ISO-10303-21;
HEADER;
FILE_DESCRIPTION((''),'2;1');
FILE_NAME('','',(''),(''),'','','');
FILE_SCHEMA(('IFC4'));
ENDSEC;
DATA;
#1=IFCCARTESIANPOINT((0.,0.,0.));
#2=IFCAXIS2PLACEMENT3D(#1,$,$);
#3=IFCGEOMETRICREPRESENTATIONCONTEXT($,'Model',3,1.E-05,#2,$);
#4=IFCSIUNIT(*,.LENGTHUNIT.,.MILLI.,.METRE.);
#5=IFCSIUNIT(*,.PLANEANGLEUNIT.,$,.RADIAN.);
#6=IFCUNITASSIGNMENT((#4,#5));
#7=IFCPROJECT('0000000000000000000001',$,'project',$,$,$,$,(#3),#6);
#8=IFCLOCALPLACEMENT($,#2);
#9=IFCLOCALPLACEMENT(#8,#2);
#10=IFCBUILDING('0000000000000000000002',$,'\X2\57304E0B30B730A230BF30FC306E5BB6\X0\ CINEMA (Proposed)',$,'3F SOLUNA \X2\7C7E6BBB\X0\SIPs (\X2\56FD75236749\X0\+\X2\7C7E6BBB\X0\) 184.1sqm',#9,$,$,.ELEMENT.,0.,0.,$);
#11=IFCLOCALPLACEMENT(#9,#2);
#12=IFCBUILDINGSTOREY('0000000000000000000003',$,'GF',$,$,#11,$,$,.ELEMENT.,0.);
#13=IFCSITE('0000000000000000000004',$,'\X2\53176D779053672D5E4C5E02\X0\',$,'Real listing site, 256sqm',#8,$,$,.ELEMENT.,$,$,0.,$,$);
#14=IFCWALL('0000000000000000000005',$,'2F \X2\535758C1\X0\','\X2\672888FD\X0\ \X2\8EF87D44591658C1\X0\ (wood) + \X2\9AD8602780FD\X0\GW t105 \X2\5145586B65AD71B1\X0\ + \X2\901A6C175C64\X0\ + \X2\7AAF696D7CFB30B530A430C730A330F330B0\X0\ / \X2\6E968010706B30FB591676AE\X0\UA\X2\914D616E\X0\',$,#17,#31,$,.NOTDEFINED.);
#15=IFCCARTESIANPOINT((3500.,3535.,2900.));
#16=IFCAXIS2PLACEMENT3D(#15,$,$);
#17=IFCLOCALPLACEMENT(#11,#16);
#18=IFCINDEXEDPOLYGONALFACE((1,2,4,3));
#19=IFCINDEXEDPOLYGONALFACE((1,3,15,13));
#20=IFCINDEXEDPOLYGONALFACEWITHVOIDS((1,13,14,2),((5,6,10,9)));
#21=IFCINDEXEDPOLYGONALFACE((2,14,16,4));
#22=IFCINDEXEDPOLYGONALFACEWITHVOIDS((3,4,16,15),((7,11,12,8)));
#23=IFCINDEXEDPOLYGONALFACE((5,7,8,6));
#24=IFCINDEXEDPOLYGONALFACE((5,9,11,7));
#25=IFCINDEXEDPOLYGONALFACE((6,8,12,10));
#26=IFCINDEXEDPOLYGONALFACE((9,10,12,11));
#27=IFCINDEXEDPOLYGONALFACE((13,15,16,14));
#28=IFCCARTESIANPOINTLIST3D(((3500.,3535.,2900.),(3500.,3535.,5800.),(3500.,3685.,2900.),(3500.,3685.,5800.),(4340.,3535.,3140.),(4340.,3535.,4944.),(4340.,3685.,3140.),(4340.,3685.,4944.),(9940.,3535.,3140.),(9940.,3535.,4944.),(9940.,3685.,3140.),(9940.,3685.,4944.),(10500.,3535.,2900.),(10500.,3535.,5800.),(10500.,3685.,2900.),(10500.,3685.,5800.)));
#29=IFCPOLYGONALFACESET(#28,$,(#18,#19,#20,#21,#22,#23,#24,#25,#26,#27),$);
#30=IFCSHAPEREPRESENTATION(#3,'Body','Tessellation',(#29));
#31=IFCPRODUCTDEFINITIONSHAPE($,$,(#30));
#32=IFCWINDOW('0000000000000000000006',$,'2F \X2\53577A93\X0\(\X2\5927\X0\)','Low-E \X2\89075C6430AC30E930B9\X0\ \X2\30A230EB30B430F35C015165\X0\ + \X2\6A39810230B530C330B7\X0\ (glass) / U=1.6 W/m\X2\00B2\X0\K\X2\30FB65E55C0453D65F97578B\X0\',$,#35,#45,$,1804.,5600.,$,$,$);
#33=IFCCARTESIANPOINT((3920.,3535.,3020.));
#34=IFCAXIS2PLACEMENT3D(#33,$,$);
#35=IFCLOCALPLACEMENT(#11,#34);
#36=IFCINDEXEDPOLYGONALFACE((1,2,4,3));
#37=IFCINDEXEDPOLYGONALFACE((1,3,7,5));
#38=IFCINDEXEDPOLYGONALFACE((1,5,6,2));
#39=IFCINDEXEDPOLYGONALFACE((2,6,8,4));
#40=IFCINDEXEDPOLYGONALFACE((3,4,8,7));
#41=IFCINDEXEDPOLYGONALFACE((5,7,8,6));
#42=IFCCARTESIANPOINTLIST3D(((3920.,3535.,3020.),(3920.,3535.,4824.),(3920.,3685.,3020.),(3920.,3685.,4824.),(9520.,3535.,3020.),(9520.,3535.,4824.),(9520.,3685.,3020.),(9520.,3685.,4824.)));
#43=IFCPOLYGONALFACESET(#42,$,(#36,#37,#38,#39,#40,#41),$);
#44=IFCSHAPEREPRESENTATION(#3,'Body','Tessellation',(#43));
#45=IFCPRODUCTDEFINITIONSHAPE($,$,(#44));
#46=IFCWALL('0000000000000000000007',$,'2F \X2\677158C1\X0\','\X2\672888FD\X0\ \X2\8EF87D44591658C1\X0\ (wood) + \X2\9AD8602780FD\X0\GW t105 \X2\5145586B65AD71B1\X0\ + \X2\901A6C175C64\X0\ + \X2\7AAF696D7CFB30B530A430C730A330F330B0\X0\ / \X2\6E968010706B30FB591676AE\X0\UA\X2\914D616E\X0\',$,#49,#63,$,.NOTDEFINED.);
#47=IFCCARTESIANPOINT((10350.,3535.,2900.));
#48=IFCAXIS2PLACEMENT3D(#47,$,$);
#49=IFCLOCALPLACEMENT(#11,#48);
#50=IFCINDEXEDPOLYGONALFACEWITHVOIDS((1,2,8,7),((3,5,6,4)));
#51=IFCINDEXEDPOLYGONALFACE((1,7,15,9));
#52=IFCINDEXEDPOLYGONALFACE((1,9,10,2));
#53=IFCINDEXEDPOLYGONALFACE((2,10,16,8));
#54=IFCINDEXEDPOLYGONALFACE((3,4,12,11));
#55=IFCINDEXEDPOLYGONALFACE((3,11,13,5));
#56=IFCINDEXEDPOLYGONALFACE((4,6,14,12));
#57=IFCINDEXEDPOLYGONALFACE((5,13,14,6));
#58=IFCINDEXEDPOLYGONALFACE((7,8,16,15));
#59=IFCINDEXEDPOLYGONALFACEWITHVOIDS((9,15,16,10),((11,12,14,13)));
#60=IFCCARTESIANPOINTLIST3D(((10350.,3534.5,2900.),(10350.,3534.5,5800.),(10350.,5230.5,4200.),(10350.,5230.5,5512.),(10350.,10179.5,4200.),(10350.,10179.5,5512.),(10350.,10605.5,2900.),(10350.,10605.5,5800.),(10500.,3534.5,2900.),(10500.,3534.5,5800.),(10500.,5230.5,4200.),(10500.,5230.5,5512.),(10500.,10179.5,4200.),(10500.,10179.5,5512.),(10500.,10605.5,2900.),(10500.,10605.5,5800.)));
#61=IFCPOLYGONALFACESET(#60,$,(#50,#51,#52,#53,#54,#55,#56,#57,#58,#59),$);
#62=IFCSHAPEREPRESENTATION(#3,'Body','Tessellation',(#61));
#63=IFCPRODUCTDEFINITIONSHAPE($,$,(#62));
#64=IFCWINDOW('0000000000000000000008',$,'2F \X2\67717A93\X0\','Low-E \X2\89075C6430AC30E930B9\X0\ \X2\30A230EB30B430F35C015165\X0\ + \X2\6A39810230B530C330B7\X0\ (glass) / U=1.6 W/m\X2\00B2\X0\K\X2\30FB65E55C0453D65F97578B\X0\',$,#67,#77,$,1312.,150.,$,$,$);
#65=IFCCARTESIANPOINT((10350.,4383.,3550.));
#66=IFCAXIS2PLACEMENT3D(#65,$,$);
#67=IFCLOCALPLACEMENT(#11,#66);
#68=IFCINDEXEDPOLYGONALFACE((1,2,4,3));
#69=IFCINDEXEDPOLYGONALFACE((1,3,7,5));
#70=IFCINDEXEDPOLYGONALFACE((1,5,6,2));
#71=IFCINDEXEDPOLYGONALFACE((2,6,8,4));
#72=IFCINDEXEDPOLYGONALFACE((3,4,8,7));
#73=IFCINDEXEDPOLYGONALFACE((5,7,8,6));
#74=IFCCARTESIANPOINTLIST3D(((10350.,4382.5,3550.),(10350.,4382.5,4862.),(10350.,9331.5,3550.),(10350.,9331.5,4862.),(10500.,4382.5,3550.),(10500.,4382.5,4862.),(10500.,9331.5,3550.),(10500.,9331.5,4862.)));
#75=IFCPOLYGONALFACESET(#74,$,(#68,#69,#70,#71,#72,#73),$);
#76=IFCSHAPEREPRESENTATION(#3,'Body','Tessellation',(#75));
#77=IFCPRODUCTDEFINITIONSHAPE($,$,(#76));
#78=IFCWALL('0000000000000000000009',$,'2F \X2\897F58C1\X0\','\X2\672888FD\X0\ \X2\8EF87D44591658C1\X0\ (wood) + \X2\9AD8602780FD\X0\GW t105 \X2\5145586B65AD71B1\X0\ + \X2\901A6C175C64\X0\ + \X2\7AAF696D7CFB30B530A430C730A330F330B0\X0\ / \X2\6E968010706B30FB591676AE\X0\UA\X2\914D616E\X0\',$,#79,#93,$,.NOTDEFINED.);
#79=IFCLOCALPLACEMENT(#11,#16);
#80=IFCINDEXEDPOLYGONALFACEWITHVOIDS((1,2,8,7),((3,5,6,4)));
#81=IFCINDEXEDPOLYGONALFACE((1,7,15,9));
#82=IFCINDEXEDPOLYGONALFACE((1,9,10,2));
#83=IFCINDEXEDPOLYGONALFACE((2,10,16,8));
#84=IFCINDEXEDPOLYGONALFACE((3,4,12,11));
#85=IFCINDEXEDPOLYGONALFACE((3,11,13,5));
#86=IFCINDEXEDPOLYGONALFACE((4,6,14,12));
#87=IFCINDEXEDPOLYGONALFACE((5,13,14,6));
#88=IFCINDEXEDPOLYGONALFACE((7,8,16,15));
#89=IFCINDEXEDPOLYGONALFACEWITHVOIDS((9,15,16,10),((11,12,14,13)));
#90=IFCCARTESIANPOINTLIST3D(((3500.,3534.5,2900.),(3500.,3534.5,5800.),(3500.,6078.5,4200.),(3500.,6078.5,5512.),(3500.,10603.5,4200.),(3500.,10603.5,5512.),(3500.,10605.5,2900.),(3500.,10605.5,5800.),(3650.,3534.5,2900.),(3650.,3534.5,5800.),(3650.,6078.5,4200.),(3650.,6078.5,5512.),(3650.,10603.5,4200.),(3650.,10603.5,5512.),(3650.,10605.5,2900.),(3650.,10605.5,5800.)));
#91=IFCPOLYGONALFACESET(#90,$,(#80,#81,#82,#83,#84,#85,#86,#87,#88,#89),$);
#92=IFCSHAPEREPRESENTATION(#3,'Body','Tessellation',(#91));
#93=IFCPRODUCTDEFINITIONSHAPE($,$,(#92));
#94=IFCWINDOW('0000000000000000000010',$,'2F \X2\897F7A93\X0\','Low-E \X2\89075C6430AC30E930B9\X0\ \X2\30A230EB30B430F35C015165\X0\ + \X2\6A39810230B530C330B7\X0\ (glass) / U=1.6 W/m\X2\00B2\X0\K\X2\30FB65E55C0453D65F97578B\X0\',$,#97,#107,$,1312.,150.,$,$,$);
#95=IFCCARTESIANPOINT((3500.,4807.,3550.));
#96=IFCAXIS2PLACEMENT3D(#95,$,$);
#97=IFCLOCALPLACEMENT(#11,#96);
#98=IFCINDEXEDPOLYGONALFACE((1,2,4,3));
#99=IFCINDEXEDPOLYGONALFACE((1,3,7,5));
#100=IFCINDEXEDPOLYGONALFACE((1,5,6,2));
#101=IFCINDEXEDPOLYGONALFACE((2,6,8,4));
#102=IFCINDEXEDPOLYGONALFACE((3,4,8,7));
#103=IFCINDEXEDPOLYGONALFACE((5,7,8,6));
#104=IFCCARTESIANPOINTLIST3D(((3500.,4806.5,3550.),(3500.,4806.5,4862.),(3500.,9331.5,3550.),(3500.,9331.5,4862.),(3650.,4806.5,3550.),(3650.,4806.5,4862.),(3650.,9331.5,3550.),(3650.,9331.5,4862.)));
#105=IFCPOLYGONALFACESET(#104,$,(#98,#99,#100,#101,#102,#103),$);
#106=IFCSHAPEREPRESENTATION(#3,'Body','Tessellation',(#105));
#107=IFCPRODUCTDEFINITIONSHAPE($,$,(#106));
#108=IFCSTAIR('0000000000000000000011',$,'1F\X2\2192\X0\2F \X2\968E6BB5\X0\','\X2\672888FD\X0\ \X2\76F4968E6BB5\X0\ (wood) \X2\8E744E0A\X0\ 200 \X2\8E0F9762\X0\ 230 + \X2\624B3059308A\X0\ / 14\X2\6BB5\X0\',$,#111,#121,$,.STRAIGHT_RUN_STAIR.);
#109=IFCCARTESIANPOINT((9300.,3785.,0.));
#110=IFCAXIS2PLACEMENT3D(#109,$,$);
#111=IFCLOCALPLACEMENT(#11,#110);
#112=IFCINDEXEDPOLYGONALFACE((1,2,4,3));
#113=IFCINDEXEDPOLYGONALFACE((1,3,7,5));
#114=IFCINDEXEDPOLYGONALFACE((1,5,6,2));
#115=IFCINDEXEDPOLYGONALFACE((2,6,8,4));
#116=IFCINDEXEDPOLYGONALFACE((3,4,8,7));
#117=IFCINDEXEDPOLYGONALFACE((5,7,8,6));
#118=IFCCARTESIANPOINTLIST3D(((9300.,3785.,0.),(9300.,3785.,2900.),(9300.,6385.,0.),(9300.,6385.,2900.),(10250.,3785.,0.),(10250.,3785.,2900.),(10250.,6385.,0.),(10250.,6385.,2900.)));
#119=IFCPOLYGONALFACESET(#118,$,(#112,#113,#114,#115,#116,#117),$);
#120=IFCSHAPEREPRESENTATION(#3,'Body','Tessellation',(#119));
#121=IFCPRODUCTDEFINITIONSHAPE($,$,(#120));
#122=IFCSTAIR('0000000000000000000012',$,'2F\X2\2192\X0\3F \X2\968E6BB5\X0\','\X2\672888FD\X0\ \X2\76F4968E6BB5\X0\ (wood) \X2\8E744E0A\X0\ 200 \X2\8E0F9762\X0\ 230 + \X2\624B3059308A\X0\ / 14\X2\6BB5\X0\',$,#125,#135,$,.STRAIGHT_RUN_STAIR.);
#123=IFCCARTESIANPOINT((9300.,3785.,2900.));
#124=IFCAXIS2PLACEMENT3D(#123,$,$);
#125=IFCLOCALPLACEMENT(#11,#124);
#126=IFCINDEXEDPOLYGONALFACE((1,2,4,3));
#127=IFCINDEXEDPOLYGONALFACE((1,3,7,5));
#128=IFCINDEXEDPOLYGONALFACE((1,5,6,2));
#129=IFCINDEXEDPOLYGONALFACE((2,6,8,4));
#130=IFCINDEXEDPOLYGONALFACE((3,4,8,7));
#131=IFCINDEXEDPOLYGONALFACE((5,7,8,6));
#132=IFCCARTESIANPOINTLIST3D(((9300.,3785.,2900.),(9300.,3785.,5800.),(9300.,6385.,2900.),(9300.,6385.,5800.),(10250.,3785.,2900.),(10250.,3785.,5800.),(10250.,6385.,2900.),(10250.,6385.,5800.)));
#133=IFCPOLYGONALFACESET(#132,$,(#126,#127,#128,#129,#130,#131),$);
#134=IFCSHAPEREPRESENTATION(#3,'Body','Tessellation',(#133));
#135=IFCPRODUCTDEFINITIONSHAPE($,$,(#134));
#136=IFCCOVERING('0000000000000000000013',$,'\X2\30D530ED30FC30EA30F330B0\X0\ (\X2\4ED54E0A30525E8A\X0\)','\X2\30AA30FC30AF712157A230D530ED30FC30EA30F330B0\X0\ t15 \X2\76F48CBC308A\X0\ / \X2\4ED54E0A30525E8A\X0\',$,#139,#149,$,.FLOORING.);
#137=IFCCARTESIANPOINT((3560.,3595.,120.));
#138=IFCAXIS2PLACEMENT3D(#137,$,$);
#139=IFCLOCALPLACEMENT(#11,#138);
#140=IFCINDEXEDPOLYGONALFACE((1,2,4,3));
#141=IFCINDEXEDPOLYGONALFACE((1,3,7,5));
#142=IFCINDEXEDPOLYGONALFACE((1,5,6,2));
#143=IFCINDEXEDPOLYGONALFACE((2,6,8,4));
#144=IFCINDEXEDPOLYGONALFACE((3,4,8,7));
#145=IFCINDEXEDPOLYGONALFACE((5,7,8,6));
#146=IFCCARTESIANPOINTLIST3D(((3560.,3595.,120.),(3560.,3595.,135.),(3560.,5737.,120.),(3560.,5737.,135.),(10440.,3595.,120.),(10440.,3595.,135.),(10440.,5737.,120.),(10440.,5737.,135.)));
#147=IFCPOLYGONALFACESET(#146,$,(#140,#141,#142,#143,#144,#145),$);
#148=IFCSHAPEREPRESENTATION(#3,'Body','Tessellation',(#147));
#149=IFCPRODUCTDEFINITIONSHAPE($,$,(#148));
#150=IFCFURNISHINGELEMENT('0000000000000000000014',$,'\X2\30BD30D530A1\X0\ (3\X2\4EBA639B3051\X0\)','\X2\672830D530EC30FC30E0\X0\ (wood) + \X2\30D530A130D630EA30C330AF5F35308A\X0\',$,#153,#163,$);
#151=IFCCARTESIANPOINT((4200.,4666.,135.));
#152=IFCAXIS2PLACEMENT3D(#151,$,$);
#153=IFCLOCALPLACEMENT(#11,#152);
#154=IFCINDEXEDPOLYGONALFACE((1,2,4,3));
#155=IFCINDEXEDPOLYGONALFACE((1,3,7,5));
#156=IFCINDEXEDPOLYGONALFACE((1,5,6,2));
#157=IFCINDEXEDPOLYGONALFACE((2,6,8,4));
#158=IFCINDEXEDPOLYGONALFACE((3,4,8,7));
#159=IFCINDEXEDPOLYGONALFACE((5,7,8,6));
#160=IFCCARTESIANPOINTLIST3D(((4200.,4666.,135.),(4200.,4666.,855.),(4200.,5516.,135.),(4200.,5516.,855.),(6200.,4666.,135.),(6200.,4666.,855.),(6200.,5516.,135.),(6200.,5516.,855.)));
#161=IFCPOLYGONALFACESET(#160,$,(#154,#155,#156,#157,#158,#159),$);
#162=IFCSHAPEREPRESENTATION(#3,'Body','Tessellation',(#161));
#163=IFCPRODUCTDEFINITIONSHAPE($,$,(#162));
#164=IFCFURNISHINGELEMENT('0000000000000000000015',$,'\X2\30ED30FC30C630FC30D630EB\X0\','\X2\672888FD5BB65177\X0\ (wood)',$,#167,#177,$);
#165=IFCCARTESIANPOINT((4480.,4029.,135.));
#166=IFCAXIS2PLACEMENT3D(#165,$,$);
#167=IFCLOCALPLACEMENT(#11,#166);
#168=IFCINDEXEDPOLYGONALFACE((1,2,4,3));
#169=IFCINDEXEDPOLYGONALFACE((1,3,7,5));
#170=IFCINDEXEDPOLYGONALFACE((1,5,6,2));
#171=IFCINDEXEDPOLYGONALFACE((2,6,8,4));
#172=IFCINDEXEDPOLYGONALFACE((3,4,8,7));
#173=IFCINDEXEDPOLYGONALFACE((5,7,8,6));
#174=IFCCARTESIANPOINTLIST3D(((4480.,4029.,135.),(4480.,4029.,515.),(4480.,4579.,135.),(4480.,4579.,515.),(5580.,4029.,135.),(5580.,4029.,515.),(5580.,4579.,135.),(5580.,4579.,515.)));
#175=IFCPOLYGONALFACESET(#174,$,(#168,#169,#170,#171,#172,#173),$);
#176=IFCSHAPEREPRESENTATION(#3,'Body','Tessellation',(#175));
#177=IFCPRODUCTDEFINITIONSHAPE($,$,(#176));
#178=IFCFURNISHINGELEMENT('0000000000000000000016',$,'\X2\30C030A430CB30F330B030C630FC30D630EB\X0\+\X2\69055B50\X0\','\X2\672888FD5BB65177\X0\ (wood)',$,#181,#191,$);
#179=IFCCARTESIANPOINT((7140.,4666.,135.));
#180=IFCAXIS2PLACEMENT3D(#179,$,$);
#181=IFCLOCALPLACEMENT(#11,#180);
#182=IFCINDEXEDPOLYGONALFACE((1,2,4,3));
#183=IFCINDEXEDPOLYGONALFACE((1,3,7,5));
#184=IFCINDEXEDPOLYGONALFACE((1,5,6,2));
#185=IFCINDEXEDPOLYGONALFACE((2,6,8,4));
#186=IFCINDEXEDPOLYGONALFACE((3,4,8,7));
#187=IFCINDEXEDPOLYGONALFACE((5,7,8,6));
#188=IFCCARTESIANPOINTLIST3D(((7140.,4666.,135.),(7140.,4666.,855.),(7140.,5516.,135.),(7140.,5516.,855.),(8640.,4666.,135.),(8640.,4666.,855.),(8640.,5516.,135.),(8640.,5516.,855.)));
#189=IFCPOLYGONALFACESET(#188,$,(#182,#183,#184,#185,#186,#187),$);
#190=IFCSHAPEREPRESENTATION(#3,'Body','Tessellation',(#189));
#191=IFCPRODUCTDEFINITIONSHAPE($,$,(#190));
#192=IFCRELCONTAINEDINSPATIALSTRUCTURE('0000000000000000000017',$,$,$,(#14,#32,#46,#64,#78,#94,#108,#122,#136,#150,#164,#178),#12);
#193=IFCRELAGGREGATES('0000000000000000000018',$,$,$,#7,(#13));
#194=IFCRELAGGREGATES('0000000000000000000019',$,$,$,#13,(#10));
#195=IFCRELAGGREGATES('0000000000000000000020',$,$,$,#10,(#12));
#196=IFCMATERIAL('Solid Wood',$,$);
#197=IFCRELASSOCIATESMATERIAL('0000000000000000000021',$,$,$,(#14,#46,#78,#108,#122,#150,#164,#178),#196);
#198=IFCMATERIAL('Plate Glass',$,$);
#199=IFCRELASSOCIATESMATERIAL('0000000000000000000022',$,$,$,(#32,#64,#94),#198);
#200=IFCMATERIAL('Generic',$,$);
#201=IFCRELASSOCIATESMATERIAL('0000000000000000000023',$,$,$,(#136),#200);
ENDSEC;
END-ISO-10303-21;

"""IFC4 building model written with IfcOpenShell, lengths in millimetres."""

from ifc_helpers import new_model, si_unit, frame, frame_2d, origin, place, context, project, spatial, rectangle, extrude, material, element, fill, save


model = new_model("IFC4")

# Units and contexts
model_context = context("Model", 3, precision=1e-05, world=origin())
ifc_project = project(units=[si_unit("LENGTHUNIT", "METRE", prefix="MILLI"), si_unit("PLANEANGLEUNIT", "RADIAN")], contexts=[model_context])

# Site, building, storey
site_placement = place(None, origin())
site = spatial("IfcSite", under=ifc_project, at=site_placement, Name="北海道札幌市", ObjectType="Real listing site, 256sqm", CompositionType="ELEMENT", RefElevation=0.0)
building_placement = place(site_placement, origin())
building = spatial("IfcBuilding", under=site, at=building_placement, Name="地下シアターの家 CINEMA (Proposed)", ObjectType="3F SOLUNA 籾殻SIPs (国産杉+籾殻) 184.1sqm", CompositionType="ELEMENT", ElevationOfRefHeight=0.0, ElevationOfTerrain=0.0)
storey_placement = place(building_placement, origin())
storey = spatial("IfcBuildingStorey", under=building, at=storey_placement, Name="GF", CompositionType="ELEMENT", Elevation=0.0)

# Shared definitions
ifc_material_1 = material(Name="Solid Wood")

# Shared definitions
ifc_material_2 = material(Name="Plate Glass")

# Walls, openings, windows
wall_1_placement = place(storey_placement, frame((3500.0, 3535.0, 2900.0)))
wall_1 = element("IfcWall", 1, at=wall_1_placement, inside=storey, material=ifc_material_1, Name="2F 南壁", Description="木製 軸組外壁 (wood) + 高性能GW t105 充填断熱 + 通気層 + 窯業系サイディング / 準耐火・外皮UA配慮", PredefinedType="NOTDEFINED", context=model_context, shape_type="SweptSolid", body=[
    extrude(rectangle(XDim=7000.0, YDim=150.0, at=frame_2d((3500.0, 75.0))), frame((3500.0, 3535.0, 2900.0)), (0.0, 0.0, 1.0), 2900.0),
])
opening_1_placement = place(storey_placement, frame((3920.0, 3535.0, 3020.0)))
opening_1 = element("IfcOpeningElement", 2, at=opening_1_placement, cuts=wall_1, PredefinedType="NOTDEFINED", context=model_context, shape_type="SweptSolid", body=[
    extrude(rectangle(XDim=5600.0, YDim=150.0, at=frame_2d((2800.0, 75.0))), frame((3920.0, 3535.0, 3020.0)), (0.0, 0.0, 1.0), 1804.0),
])
window_1_placement = place(storey_placement, frame((3920.0, 3535.0, 3020.0)))
window_1 = element("IfcWindow", 3, at=window_1_placement, inside=storey, material=ifc_material_2, Name="2F 南窓(大)", Description="Low-E 複層ガラス アルゴン封入 + 樹脂サッシ (glass) / U=1.6 W/m²K・日射取得型", OverallHeight=1804.0, OverallWidth=5600.0, context=model_context, shape_type="SweptSolid", body=[
    extrude(rectangle(XDim=5600.0, YDim=150.0, at=frame_2d((2800.0, 75.0))), frame((3920.0, 3535.0, 3020.0)), (0.0, 0.0, 1.0), 1804.0),
])
fill(opening_1, window_1)
wall_2_placement = place(storey_placement, frame((10350.0, 3535.0, 2900.0)))
wall_2 = element("IfcWall", 4, at=wall_2_placement, inside=storey, material=ifc_material_1, Name="2F 東壁", Description="木製 軸組外壁 (wood) + 高性能GW t105 充填断熱 + 通気層 + 窯業系サイディング / 準耐火・外皮UA配慮", PredefinedType="NOTDEFINED", context=model_context, shape_type="SweptSolid", body=[
    extrude(rectangle(XDim=150.0, YDim=7071.0, at=frame_2d((75.0, 3535.0))), frame((10350.0, 3535.0, 2900.0)), (0.0, 0.0, 1.0), 2900.0),
])
opening_2_placement = place(storey_placement, frame((10350.0, 4383.0, 3550.0)))
opening_2 = element("IfcOpeningElement", 5, at=opening_2_placement, cuts=wall_2, PredefinedType="NOTDEFINED", context=model_context, shape_type="SweptSolid", body=[
    extrude(rectangle(XDim=150.0, YDim=4949.0, at=frame_2d((75.0, 2474.0))), frame((10350.0, 4383.0, 3550.0)), (0.0, 0.0, 1.0), 1312.0),
])
window_2_placement = place(storey_placement, frame((10350.0, 4383.0, 3550.0)))
window_2 = element("IfcWindow", 6, at=window_2_placement, inside=storey, material=ifc_material_2, Name="2F 東窓", Description="Low-E 複層ガラス アルゴン封入 + 樹脂サッシ (glass) / U=1.6 W/m²K・日射取得型", OverallHeight=1312.0, OverallWidth=150.0, context=model_context, shape_type="SweptSolid", body=[
    extrude(rectangle(XDim=150.0, YDim=4949.0, at=frame_2d((75.0, 2474.0))), frame((10350.0, 4383.0, 3550.0)), (0.0, 0.0, 1.0), 1312.0),
])
fill(opening_2, window_2)
wall_3_placement = place(storey_placement, frame((3500.0, 3535.0, 2900.0)))
wall_3 = element("IfcWall", 7, at=wall_3_placement, inside=storey, material=ifc_material_1, Name="2F 西壁", Description="木製 軸組外壁 (wood) + 高性能GW t105 充填断熱 + 通気層 + 窯業系サイディング / 準耐火・外皮UA配慮", PredefinedType="NOTDEFINED", context=model_context, shape_type="SweptSolid", body=[
    extrude(rectangle(XDim=150.0, YDim=7071.0, at=frame_2d((75.0, 3535.0))), frame((3500.0, 3535.0, 2900.0)), (0.0, 0.0, 1.0), 2900.0),
])
opening_3_placement = place(storey_placement, frame((3500.0, 4807.0, 3550.0)))
opening_3 = element("IfcOpeningElement", 8, at=opening_3_placement, cuts=wall_3, PredefinedType="NOTDEFINED", context=model_context, shape_type="SweptSolid", body=[
    extrude(rectangle(XDim=150.0, YDim=4525.0, at=frame_2d((75.0, 2262.0))), frame((3500.0, 4807.0, 3550.0)), (0.0, 0.0, 1.0), 1312.0),
])
window_3_placement = place(storey_placement, frame((3500.0, 4807.0, 3550.0)))
window_3 = element("IfcWindow", 9, at=window_3_placement, inside=storey, material=ifc_material_2, Name="2F 西窓", Description="Low-E 複層ガラス アルゴン封入 + 樹脂サッシ (glass) / U=1.6 W/m²K・日射取得型", OverallHeight=1312.0, OverallWidth=150.0, context=model_context, shape_type="SweptSolid", body=[
    extrude(rectangle(XDim=150.0, YDim=4525.0, at=frame_2d((75.0, 2262.0))), frame((3500.0, 4807.0, 3550.0)), (0.0, 0.0, 1.0), 1312.0),
])
fill(opening_3, window_3)

# Stairs
stair_1_placement = place(storey_placement, frame((9300.0, 3785.0, 0.0)))
element("IfcStair", 10, at=stair_1_placement, inside=storey, material=ifc_material_1, Name="1F→2F 階段", Description="木製 直階段 (wood) 蹴上 200 踏面 230 + 手すり / 14段", PredefinedType="STRAIGHT_RUN_STAIR", context=model_context, shape_type="SweptSolid", body=[
    extrude(rectangle(XDim=950.0, YDim=2600.0, at=frame_2d((475.0, 1300.0))), frame((9300.0, 3785.0, 0.0)), (0.0, 0.0, 1.0), 2900.0),
])
stair_2_placement = place(storey_placement, frame((9300.0, 3785.0, 2900.0)))
element("IfcStair", 11, at=stair_2_placement, inside=storey, material=ifc_material_1, Name="2F→3F 階段", Description="木製 直階段 (wood) 蹴上 200 踏面 230 + 手すり / 14段", PredefinedType="STRAIGHT_RUN_STAIR", context=model_context, shape_type="SweptSolid", body=[
    extrude(rectangle(XDim=950.0, YDim=2600.0, at=frame_2d((475.0, 1300.0))), frame((9300.0, 3785.0, 2900.0)), (0.0, 0.0, 1.0), 2900.0),
])

# Covering
ifc_material_3 = material(Name="Generic")
covering_placement = place(storey_placement, frame((3560.0, 3595.0, 120.0)))
element("IfcCovering", 12, at=covering_placement, inside=storey, material=ifc_material_3, Name="フローリング (仕上げ床)", Description="オーク無垢フローリング t15 直貼り / 仕上げ床", PredefinedType="FLOORING", context=model_context, shape_type="SweptSolid", body=[
    extrude(rectangle(XDim=6880.0, YDim=2142.0, at=frame_2d((3440.0, 1071.0))), frame((3560.0, 3595.0, 120.0)), (0.0, 0.0, 1.0), 15.0),
])

# Furnishing elements
furnishing_1_placement = place(storey_placement, frame((4200.0, 4666.0, 135.0)))
element("IfcFurnishingElement", 13, at=furnishing_1_placement, inside=storey, material=ifc_material_1, Name="ソファ (3人掛け)", Description="木フレーム (wood) + ファブリック張り", context=model_context, shape_type="SweptSolid", body=[
    extrude(rectangle(XDim=2000.0, YDim=850.0, at=frame_2d((1000.0, 425.0))), frame((4200.0, 4666.0, 135.0)), (0.0, 0.0, 1.0), 720.0),
])
furnishing_2_placement = place(storey_placement, frame((4480.0, 4029.0, 135.0)))
element("IfcFurnishingElement", 14, at=furnishing_2_placement, inside=storey, material=ifc_material_1, Name="ローテーブル", Description="木製家具 (wood)", context=model_context, shape_type="SweptSolid", body=[
    extrude(rectangle(XDim=1100.0, YDim=550.0, at=frame_2d((550.0, 275.0))), frame((4480.0, 4029.0, 135.0)), (0.0, 0.0, 1.0), 380.0),
])
furnishing_3_placement = place(storey_placement, frame((7140.0, 4666.0, 135.0)))
element("IfcFurnishingElement", 15, at=furnishing_3_placement, inside=storey, material=ifc_material_1, Name="ダイニングテーブル+椅子", Description="木製家具 (wood)", context=model_context, shape_type="SweptSolid", body=[
    extrude(rectangle(XDim=1500.0, YDim=850.0, at=frame_2d((750.0, 425.0))), frame((7140.0, 4666.0, 135.0)), (0.0, 0.0, 1.0), 720.0),
])

save(model, "model.ifc")
